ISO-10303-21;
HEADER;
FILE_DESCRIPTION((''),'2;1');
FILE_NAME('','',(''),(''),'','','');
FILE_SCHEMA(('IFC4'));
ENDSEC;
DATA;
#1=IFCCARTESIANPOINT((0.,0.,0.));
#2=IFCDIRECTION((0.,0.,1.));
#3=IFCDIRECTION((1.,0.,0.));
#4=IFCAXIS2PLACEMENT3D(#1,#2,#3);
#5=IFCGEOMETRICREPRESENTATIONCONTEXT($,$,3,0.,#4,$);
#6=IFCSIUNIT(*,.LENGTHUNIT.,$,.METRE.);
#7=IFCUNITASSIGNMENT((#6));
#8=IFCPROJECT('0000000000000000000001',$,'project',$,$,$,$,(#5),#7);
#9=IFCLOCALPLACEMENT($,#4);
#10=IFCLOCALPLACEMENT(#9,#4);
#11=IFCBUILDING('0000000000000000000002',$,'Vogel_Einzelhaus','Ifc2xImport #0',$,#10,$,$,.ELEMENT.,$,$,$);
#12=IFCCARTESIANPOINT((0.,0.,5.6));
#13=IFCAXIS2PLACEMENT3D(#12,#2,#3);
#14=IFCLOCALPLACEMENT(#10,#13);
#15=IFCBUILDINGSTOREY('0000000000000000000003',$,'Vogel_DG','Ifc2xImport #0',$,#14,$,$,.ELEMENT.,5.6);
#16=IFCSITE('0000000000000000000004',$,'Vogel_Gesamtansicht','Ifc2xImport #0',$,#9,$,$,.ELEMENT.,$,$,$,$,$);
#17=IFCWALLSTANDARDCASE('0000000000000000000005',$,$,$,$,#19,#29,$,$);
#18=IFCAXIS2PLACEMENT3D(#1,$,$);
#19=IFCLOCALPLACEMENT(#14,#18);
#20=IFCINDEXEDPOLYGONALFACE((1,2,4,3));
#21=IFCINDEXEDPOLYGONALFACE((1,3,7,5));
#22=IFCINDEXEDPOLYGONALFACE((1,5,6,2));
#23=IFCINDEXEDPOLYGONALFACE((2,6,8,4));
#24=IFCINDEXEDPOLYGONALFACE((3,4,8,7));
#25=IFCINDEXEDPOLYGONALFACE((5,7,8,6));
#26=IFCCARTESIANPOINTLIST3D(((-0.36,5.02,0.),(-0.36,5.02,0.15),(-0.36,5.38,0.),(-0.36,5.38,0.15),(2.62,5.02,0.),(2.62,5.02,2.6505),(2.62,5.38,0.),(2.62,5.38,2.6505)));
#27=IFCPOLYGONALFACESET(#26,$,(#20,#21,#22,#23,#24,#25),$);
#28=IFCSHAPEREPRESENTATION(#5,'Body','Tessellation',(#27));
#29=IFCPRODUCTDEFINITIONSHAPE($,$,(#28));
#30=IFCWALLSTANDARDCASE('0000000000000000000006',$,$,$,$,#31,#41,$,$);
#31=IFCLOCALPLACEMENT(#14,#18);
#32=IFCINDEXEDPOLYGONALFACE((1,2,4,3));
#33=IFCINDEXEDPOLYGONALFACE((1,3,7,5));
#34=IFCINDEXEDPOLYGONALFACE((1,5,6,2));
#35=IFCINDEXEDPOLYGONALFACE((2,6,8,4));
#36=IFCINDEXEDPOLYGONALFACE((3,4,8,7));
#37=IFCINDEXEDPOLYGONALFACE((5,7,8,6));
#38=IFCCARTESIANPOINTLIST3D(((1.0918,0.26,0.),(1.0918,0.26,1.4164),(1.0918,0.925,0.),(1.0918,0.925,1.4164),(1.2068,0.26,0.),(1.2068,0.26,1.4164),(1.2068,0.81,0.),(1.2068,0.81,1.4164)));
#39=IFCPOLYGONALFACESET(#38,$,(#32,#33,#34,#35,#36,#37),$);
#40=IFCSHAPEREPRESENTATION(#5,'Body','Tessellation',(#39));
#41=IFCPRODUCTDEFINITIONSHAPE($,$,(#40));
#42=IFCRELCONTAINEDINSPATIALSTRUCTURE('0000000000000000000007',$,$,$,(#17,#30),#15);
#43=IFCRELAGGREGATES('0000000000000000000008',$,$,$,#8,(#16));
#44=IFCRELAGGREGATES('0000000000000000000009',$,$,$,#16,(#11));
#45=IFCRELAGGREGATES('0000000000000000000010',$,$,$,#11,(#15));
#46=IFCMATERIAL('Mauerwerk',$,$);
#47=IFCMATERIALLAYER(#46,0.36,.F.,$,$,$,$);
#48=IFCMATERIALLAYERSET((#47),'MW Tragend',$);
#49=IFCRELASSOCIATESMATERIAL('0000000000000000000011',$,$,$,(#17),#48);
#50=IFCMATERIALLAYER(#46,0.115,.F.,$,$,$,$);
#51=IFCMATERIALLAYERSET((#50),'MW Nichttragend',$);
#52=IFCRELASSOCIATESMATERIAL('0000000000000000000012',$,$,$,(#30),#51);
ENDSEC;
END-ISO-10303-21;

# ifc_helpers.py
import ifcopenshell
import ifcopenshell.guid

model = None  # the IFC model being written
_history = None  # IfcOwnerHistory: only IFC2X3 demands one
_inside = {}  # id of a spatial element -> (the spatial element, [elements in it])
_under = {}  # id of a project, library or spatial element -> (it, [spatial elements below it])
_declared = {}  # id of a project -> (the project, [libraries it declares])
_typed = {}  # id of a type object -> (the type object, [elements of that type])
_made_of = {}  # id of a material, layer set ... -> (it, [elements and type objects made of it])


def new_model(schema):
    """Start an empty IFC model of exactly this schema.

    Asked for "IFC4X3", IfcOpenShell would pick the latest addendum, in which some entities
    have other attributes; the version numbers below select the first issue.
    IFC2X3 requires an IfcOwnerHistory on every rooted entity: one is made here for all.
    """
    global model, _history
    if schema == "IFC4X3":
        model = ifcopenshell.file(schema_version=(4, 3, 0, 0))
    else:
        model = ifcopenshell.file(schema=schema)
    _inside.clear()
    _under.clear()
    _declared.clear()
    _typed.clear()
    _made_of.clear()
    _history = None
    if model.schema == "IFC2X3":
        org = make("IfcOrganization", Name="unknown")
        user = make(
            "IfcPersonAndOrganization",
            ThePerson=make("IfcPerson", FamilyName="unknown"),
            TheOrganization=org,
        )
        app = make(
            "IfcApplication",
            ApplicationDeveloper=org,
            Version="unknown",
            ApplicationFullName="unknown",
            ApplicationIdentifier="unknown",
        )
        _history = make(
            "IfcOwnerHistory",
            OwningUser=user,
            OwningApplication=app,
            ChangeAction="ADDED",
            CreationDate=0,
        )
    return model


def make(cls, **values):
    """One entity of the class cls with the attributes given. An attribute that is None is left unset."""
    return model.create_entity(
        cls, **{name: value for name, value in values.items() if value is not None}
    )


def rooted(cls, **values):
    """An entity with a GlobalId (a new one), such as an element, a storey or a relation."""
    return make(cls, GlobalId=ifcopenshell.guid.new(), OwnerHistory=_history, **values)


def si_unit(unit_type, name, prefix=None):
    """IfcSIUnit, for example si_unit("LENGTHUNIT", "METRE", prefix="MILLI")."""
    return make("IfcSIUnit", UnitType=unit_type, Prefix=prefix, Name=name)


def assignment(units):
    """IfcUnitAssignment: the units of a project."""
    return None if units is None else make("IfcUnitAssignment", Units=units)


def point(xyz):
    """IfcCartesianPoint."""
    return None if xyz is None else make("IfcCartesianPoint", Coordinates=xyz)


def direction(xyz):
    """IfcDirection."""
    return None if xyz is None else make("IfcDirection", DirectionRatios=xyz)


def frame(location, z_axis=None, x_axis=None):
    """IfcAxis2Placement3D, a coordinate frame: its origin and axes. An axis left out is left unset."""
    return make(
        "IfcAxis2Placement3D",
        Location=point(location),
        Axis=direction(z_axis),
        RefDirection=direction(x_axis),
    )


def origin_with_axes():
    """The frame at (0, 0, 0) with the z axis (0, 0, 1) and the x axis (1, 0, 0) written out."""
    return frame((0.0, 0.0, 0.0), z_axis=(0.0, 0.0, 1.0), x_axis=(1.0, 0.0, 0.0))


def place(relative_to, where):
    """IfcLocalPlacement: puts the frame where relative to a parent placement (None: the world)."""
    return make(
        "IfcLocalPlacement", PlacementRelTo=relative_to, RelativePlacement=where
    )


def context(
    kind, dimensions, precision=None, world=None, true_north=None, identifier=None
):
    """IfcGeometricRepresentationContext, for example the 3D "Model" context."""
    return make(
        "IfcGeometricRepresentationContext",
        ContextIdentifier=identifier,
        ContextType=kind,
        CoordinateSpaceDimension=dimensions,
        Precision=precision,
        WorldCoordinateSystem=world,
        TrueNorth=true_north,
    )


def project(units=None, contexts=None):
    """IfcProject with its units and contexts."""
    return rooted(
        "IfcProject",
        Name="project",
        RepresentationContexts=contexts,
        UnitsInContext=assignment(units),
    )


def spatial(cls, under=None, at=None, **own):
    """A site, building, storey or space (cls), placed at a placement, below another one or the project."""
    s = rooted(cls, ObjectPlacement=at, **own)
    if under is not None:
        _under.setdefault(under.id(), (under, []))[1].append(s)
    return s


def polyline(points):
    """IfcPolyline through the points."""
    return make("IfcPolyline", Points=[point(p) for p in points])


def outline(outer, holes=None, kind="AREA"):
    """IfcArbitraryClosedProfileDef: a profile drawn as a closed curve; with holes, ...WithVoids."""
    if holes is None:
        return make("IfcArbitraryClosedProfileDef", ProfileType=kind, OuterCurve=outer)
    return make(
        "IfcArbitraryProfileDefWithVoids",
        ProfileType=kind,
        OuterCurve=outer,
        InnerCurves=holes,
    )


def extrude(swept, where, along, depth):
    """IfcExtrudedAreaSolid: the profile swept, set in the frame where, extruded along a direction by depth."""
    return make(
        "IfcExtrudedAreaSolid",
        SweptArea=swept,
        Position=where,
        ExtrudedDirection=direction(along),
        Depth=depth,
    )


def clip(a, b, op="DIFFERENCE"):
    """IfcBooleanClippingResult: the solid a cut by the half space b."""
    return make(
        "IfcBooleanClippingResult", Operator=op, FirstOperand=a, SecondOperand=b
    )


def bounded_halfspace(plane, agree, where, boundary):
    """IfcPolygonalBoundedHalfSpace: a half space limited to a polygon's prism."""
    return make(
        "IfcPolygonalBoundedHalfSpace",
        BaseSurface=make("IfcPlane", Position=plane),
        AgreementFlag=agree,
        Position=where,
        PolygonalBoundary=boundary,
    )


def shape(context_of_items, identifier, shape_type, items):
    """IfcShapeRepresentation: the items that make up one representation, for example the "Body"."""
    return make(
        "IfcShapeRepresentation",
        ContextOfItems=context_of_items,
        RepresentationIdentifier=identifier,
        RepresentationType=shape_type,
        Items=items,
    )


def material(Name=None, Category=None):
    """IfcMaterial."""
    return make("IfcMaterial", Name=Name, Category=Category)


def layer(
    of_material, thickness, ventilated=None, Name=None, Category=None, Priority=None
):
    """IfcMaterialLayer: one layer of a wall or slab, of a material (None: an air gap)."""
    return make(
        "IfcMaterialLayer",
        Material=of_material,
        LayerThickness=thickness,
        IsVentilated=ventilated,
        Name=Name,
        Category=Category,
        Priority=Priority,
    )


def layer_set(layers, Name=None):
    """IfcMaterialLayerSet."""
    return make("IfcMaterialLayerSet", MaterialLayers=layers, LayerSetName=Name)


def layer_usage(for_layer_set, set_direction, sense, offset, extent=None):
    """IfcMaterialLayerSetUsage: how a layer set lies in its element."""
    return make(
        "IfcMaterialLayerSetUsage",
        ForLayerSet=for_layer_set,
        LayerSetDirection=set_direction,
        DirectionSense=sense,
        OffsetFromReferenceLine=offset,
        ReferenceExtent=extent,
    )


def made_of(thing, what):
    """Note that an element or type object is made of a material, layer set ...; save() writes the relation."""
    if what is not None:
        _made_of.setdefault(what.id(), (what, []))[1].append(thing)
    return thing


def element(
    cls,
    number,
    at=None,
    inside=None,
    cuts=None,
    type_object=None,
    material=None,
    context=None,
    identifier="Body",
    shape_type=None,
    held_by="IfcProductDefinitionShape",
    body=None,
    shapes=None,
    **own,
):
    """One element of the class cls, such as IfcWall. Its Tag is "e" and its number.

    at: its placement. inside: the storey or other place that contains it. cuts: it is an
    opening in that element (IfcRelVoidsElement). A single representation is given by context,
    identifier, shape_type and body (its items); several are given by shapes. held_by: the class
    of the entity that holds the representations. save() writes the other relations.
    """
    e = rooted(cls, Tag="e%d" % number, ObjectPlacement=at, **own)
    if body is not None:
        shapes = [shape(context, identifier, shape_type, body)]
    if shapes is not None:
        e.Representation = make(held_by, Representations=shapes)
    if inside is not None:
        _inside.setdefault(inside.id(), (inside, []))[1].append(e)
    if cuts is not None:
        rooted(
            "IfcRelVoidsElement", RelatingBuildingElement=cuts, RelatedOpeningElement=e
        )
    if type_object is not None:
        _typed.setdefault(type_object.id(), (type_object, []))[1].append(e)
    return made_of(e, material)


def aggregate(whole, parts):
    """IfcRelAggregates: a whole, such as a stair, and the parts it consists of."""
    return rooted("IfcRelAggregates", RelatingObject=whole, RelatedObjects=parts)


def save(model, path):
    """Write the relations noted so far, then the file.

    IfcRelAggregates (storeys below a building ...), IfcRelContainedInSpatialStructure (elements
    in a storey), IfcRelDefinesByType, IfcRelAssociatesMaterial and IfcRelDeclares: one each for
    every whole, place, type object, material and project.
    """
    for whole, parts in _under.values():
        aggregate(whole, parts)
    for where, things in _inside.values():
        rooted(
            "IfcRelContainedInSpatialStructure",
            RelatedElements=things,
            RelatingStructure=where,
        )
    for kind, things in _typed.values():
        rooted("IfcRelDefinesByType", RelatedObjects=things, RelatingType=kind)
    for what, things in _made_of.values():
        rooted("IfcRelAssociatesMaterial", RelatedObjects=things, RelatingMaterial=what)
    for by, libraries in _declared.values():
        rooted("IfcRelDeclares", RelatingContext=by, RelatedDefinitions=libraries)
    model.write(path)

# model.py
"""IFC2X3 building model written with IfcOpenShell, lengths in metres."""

from ifc_helpers import new_model, si_unit, frame, origin_with_axes, place, context, project, spatial, polyline, outline, extrude, clip, bounded_halfspace, material, layer, layer_set, layer_usage, element, save


model = new_model("IFC2X3")

# Units and contexts
context_of_model = context(None, 3, precision=0.0, world=origin_with_axes())
ifc_project = project(units=[si_unit("LENGTHUNIT", "METRE")], contexts=[context_of_model])

# Site, building, storey
site_placement = place(None, origin_with_axes())
site = spatial("IfcSite", under=ifc_project, at=site_placement, Name="Vogel_Gesamtansicht", Description="Ifc2xImport #0", CompositionType="ELEMENT")
building_placement = place(site_placement, origin_with_axes())
building = spatial("IfcBuilding", under=site, at=building_placement, Name="Vogel_Einzelhaus", Description="Ifc2xImport #0", CompositionType="ELEMENT")
storey_placement = place(building_placement, frame((0.0, 0.0, 5.6), z_axis=(0.0, 0.0, 1.0), x_axis=(1.0, 0.0, 0.0)))
storey = spatial("IfcBuildingStorey", under=building, at=storey_placement, Name="Vogel_DG", Description="Ifc2xImport #0", CompositionType="ELEMENT", Elevation=5.6)

# Shared definitions
ifc_material_1 = material(Name="Mauerwerk")

# Shared definitions
ifc_layer_1 = layer(ifc_material_1, 0.36, ventilated=False)
ifc_layer_set_1 = layer_set([ifc_layer_1], Name="MW Tragend")

# Shared definitions
ifc_layer_usage_1 = layer_usage(ifc_layer_set_1, "AXIS2", "POSITIVE", 0.0)

# Walls
ifc_layer_2 = layer(ifc_material_1, 0.115, ventilated=False)
ifc_layer_set_2 = layer_set([ifc_layer_2], Name="MW Nichttragend")
wall_1_placement = place(storey_placement, frame((2.62, 5.38, 0.0), z_axis=(0.0, 0.0, 1.0), x_axis=(-1.0, 0.0, 0.0)))
element("IfcWallStandardCase", 1, at=wall_1_placement, inside=storey, material=ifc_layer_usage_1, context=context_of_model, shape_type="Clipping", body=[
    clip(extrude(outline(polyline([(2.44, 0.0), (2.98, 0.0), (2.98, 0.36), (2.44, 0.36), (1.5282, 0.36), (1.4782, 0.36), (1.4282, 0.36), (0.0, 0.36), (0.0, 0.0), (1.4782, 0.0), (2.44, 0.0)])), origin_with_axes(), (0.0, 0.0, 1.0), 2.6505), bounded_halfspace(frame((0.0, 0.0, 2.6505), z_axis=(-0.642788, 0.0, -0.766044), x_axis=(0.766044, 0.0, -0.642788)), True, origin_with_axes(), polyline([(-2.98, -0.36), (2.98, -0.36), (2.98, 0.36), (-2.98, 0.36), (-2.98, -0.36)]))),
])
ifc_layer_usage_2 = layer_usage(ifc_layer_set_2, "AXIS2", "POSITIVE", 0.0)
wall_2_placement = place(storey_placement, frame((1.0918, 0.925, 0.0), z_axis=(0.0, 0.0, 1.0), x_axis=(0.0, -1.0, 0.0)))
element("IfcWallStandardCase", 2, at=wall_2_placement, inside=storey, material=ifc_layer_usage_2, context=context_of_model, shape_type="Clipping", body=[
    clip(extrude(outline(polyline([(0.115, 0.115), (0.0, 0.0), (0.665, 0.0), (0.665, 0.115), (0.115, 0.115)])), origin_with_axes(), (0.0, 0.0, 1.0), 1.4164), bounded_halfspace(frame((0.0, 0.0, 1.4164), z_axis=(0.0, 0.0, -1.0), x_axis=(1.0, 0.0, 0.0)), True, origin_with_axes(), polyline([(-0.665, -0.115), (0.665, -0.115), (0.665, 0.115), (-0.665, 0.115), (-0.665, -0.115)]))),
])

save(model, "model.ifc")
